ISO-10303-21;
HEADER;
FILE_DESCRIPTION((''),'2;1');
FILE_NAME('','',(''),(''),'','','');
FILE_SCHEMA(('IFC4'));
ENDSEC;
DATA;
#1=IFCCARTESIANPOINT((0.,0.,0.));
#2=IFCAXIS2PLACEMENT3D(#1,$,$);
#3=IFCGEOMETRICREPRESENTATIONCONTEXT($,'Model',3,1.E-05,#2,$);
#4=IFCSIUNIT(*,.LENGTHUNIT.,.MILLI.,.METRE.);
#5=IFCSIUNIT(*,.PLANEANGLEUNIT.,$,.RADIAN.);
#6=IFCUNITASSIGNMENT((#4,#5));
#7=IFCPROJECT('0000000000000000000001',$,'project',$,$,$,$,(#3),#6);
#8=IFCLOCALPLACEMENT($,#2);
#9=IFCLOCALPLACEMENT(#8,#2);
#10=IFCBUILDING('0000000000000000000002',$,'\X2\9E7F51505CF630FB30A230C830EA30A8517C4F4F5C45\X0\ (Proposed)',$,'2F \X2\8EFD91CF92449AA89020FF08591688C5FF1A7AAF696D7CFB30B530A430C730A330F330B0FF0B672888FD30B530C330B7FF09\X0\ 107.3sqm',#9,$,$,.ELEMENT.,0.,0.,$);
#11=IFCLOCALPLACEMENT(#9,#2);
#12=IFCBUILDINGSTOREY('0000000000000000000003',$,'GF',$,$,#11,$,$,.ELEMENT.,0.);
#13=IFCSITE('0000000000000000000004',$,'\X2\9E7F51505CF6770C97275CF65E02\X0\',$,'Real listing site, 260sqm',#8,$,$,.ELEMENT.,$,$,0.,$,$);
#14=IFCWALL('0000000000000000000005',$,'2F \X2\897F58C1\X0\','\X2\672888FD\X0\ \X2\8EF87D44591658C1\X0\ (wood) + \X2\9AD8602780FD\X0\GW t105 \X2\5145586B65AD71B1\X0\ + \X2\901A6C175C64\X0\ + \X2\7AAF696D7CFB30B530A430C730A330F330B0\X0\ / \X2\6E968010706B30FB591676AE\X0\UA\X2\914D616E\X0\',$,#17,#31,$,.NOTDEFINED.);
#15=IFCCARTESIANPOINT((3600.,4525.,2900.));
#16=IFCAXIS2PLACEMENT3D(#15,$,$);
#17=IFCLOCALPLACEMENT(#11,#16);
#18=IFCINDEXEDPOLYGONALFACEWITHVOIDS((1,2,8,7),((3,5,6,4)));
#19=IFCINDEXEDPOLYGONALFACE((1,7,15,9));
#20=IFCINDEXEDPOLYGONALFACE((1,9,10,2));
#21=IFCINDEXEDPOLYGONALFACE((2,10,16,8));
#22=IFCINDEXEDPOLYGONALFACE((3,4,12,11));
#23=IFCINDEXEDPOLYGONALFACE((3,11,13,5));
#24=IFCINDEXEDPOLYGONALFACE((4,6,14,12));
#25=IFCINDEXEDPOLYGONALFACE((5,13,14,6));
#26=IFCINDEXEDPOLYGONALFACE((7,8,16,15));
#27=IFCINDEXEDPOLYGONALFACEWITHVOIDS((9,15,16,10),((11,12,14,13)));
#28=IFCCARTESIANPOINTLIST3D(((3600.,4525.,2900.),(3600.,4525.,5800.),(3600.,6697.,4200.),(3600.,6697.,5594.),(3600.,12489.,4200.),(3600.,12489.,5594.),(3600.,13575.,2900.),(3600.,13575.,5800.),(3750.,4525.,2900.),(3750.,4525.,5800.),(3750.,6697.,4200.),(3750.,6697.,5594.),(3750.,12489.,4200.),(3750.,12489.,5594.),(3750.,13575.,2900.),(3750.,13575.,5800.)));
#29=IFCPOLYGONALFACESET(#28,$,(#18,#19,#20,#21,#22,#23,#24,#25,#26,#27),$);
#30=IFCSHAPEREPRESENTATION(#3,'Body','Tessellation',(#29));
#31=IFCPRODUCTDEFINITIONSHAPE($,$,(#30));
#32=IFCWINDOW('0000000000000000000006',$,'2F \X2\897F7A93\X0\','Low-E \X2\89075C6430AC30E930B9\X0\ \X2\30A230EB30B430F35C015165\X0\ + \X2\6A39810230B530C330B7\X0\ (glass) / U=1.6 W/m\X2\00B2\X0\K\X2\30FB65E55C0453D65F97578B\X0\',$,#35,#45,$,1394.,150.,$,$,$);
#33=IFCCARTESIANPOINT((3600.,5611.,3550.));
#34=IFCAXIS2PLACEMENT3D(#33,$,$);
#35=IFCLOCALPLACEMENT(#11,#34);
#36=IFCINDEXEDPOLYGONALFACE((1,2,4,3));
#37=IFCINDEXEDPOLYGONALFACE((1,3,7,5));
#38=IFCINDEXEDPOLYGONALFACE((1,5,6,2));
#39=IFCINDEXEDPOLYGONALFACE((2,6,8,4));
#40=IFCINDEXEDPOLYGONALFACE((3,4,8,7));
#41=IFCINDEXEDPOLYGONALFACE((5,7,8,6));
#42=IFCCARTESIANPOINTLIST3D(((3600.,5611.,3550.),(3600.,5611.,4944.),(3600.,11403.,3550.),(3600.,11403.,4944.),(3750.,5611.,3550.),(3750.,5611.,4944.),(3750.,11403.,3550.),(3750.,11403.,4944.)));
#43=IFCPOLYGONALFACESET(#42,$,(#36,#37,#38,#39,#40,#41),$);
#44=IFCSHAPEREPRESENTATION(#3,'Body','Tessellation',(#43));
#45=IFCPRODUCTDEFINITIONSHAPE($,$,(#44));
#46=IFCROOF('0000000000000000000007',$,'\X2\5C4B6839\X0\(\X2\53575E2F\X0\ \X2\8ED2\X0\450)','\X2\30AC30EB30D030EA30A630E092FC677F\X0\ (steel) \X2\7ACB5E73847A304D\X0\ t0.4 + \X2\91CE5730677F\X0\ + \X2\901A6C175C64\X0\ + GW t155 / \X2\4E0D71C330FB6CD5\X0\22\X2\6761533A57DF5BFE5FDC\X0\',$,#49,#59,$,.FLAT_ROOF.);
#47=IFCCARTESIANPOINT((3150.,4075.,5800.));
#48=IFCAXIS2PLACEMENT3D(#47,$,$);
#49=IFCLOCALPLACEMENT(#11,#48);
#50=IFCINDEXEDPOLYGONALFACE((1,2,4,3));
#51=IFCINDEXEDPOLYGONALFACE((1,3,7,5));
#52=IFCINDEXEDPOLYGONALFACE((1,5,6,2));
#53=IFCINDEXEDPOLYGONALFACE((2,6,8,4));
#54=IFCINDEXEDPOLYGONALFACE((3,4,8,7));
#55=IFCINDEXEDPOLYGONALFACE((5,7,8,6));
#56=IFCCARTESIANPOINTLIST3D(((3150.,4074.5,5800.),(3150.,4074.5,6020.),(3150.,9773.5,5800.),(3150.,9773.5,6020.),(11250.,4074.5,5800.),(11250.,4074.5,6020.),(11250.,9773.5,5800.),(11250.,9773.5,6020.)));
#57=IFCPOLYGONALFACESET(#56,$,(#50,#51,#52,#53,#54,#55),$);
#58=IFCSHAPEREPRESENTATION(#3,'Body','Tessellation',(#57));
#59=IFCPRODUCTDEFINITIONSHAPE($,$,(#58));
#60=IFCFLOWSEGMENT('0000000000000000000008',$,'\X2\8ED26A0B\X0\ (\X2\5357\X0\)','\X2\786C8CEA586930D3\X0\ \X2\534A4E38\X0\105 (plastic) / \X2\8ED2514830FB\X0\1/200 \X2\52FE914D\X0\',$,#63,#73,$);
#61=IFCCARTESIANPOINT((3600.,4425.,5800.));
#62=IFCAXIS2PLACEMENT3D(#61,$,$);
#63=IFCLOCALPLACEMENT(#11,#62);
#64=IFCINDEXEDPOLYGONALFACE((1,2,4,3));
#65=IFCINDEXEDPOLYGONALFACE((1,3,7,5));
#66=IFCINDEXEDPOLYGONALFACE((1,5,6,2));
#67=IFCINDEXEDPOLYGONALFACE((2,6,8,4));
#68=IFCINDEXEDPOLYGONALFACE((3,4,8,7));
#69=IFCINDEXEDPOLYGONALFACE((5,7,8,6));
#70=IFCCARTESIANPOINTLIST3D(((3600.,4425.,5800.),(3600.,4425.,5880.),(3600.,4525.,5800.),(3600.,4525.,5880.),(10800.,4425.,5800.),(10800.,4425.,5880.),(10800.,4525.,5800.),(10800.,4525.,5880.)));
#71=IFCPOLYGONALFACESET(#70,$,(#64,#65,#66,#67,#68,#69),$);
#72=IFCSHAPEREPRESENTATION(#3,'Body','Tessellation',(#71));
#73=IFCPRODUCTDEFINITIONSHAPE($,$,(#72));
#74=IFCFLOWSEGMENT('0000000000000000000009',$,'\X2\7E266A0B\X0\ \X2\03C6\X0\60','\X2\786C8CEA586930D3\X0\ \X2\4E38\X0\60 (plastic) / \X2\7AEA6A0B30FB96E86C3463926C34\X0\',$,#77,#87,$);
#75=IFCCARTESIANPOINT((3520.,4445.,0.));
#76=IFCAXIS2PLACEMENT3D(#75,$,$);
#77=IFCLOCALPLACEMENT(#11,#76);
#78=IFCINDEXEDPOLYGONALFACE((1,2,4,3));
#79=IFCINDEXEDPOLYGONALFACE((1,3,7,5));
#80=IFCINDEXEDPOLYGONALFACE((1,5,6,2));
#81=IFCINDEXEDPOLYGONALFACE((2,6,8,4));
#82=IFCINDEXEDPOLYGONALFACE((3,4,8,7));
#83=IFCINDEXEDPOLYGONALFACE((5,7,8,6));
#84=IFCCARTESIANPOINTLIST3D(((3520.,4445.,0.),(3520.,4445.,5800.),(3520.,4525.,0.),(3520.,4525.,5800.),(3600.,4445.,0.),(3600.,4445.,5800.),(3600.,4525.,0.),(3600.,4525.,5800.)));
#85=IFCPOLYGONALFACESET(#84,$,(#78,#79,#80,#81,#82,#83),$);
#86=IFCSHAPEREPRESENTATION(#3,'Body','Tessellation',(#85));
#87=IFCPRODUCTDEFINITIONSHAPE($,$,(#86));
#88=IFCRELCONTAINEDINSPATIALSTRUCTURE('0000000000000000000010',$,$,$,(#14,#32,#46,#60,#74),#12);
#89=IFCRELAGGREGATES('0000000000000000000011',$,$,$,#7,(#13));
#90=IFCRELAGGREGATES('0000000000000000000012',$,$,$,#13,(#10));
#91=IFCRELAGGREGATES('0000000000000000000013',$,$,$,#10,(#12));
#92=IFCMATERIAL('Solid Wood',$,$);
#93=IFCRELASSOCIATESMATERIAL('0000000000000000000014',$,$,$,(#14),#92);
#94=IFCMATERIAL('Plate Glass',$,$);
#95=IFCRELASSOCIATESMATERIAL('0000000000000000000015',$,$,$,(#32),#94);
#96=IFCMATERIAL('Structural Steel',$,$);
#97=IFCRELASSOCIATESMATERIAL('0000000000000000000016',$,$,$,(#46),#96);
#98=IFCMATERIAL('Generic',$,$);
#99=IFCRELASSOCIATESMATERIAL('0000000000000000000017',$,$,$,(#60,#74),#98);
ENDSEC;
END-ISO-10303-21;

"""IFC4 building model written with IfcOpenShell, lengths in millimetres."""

from ifc_helpers import new_model, si_unit, frame, frame_2d, origin, place, context, project, spatial, rectangle, extrude, material, element, fill, save


model = new_model("IFC4")

# Units and contexts
model_context = context("Model", 3, precision=1e-05, world=origin())
ifc_project = project(units=[si_unit("LENGTHUNIT", "METRE", prefix="MILLI"), si_unit("PLANEANGLEUNIT", "RADIAN")], contexts=[model_context])

# Site, building, storey
site_placement = place(None, origin())
site = spatial("IfcSite", under=ifc_project, at=site_placement, Name="鹿児島県霧島市", ObjectType="Real listing site, 260sqm", CompositionType="ELEMENT", RefElevation=0.0)
building_placement = place(site_placement, origin())
building = spatial("IfcBuilding", under=site, at=building_placement, Name="鹿児島・アトリエ兼住居 (Proposed)", ObjectType="2F 軽量鉄骨造（外装：窯業系サイディング＋木製サッシ） 107.3sqm", CompositionType="ELEMENT", ElevationOfRefHeight=0.0, ElevationOfTerrain=0.0)
storey_placement = place(building_placement, origin())
storey = spatial("IfcBuildingStorey", under=building, at=storey_placement, Name="GF", CompositionType="ELEMENT", Elevation=0.0)

# Shared definitions
ifc_material_1 = material(Name="Solid Wood")

# Shared definitions
ifc_material_2 = material(Name="Plate Glass")

# Wall, opening, window
wall_1_placement = place(storey_placement, frame((3600.0, 4525.0, 2900.0)))
wall_1 = element("IfcWall", 1, at=wall_1_placement, inside=storey, material=ifc_material_1, Name="2F 西壁", Description="木製 軸組外壁 (wood) + 高性能GW t105 充填断熱 + 通気層 + 窯業系サイディング / 準耐火・外皮UA配慮", PredefinedType="NOTDEFINED", context=model_context, shape_type="SweptSolid", body=[
    extrude(rectangle(XDim=150.0, YDim=9050.0, at=frame_2d((75.0, 4525.0))), frame((3600.0, 4525.0, 2900.0)), (0.0, 0.0, 1.0), 2900.0),
])
opening_1_placement = place(storey_placement, frame((3600.0, 5611.0, 3550.0)))
opening_1 = element("IfcOpeningElement", 2, at=opening_1_placement, cuts=wall_1, PredefinedType="NOTDEFINED", context=model_context, shape_type="SweptSolid", body=[
    extrude(rectangle(XDim=150.0, YDim=5792.0, at=frame_2d((75.0, 2896.0))), frame((3600.0, 5611.0, 3550.0)), (0.0, 0.0, 1.0), 1394.0),
])
window_1_placement = place(storey_placement, frame((3600.0, 5611.0, 3550.0)))
window_1 = element("IfcWindow", 3, at=window_1_placement, inside=storey, material=ifc_material_2, Name="2F 西窓", Description="Low-E 複層ガラス アルゴン封入 + 樹脂サッシ (glass) / U=1.6 W/m²K・日射取得型", OverallHeight=1394.0, OverallWidth=150.0, context=model_context, shape_type="SweptSolid", body=[
    extrude(rectangle(XDim=150.0, YDim=5792.0, at=frame_2d((75.0, 2896.0))), frame((3600.0, 5611.0, 3550.0)), (0.0, 0.0, 1.0), 1394.0),
])
fill(opening_1, window_1)

# Roof
ifc_material_3 = material(Name="Structural Steel")
for number, where, name in (
    (4, (3150.0, 4075.0, 5800.0), "屋根(南帯 軒450)"),
):
    element("IfcRoof", number, at=place(storey_placement, frame(where)), inside=storey, material=ifc_material_3, Name=name, Description="ガルバリウム鋼板 (steel) 立平葺き t0.4 + 野地板 + 通気層 + GW t155 / 不燃・法22条区域対応", PredefinedType="FLAT_ROOF", context=model_context, shape_type="SweptSolid", body=[
        extrude(rectangle(XDim=8100.0, YDim=5699.0, at=frame_2d((4050.0, 2849.0))), frame((3150.0, 4075.0, 5800.0)), (0.0, 0.0, 1.0), 220.0),
    ])

# Flow segments
ifc_material_4 = material(Name="Generic")
flow_segment_1_placement = place(storey_placement, frame((3600.0, 4425.0, 5800.0)))
element("IfcFlowSegment", 5, at=flow_segment_1_placement, inside=storey, material=ifc_material_4, Name="軒樋 (南)", Description="硬質塩ビ 半丸105 (plastic) / 軒先・1/200 勾配", context=model_context, shape_type="SweptSolid", body=[
    extrude(rectangle(XDim=7200.0, YDim=100.0, at=frame_2d((3600.0, 50.0))), frame((3600.0, 4425.0, 5800.0)), (0.0, 0.0, 1.0), 80.0),
])
flow_segment_2_placement = place(storey_placement, frame((3520.0, 4445.0, 0.0)))
element("IfcFlowSegment", 6, at=flow_segment_2_placement, inside=storey, material=ifc_material_4, Name="縦樋 φ60", Description="硬質塩ビ 丸60 (plastic) / 竪樋・雨水排水", context=model_context, shape_type="SweptSolid", body=[
    extrude(rectangle(XDim=80.0, YDim=80.0, at=frame_2d((40.0, 40.0))), frame((3520.0, 4445.0, 0.0)), (0.0, 0.0, 1.0), 5800.0),
])

save(model, "model.ifc")
